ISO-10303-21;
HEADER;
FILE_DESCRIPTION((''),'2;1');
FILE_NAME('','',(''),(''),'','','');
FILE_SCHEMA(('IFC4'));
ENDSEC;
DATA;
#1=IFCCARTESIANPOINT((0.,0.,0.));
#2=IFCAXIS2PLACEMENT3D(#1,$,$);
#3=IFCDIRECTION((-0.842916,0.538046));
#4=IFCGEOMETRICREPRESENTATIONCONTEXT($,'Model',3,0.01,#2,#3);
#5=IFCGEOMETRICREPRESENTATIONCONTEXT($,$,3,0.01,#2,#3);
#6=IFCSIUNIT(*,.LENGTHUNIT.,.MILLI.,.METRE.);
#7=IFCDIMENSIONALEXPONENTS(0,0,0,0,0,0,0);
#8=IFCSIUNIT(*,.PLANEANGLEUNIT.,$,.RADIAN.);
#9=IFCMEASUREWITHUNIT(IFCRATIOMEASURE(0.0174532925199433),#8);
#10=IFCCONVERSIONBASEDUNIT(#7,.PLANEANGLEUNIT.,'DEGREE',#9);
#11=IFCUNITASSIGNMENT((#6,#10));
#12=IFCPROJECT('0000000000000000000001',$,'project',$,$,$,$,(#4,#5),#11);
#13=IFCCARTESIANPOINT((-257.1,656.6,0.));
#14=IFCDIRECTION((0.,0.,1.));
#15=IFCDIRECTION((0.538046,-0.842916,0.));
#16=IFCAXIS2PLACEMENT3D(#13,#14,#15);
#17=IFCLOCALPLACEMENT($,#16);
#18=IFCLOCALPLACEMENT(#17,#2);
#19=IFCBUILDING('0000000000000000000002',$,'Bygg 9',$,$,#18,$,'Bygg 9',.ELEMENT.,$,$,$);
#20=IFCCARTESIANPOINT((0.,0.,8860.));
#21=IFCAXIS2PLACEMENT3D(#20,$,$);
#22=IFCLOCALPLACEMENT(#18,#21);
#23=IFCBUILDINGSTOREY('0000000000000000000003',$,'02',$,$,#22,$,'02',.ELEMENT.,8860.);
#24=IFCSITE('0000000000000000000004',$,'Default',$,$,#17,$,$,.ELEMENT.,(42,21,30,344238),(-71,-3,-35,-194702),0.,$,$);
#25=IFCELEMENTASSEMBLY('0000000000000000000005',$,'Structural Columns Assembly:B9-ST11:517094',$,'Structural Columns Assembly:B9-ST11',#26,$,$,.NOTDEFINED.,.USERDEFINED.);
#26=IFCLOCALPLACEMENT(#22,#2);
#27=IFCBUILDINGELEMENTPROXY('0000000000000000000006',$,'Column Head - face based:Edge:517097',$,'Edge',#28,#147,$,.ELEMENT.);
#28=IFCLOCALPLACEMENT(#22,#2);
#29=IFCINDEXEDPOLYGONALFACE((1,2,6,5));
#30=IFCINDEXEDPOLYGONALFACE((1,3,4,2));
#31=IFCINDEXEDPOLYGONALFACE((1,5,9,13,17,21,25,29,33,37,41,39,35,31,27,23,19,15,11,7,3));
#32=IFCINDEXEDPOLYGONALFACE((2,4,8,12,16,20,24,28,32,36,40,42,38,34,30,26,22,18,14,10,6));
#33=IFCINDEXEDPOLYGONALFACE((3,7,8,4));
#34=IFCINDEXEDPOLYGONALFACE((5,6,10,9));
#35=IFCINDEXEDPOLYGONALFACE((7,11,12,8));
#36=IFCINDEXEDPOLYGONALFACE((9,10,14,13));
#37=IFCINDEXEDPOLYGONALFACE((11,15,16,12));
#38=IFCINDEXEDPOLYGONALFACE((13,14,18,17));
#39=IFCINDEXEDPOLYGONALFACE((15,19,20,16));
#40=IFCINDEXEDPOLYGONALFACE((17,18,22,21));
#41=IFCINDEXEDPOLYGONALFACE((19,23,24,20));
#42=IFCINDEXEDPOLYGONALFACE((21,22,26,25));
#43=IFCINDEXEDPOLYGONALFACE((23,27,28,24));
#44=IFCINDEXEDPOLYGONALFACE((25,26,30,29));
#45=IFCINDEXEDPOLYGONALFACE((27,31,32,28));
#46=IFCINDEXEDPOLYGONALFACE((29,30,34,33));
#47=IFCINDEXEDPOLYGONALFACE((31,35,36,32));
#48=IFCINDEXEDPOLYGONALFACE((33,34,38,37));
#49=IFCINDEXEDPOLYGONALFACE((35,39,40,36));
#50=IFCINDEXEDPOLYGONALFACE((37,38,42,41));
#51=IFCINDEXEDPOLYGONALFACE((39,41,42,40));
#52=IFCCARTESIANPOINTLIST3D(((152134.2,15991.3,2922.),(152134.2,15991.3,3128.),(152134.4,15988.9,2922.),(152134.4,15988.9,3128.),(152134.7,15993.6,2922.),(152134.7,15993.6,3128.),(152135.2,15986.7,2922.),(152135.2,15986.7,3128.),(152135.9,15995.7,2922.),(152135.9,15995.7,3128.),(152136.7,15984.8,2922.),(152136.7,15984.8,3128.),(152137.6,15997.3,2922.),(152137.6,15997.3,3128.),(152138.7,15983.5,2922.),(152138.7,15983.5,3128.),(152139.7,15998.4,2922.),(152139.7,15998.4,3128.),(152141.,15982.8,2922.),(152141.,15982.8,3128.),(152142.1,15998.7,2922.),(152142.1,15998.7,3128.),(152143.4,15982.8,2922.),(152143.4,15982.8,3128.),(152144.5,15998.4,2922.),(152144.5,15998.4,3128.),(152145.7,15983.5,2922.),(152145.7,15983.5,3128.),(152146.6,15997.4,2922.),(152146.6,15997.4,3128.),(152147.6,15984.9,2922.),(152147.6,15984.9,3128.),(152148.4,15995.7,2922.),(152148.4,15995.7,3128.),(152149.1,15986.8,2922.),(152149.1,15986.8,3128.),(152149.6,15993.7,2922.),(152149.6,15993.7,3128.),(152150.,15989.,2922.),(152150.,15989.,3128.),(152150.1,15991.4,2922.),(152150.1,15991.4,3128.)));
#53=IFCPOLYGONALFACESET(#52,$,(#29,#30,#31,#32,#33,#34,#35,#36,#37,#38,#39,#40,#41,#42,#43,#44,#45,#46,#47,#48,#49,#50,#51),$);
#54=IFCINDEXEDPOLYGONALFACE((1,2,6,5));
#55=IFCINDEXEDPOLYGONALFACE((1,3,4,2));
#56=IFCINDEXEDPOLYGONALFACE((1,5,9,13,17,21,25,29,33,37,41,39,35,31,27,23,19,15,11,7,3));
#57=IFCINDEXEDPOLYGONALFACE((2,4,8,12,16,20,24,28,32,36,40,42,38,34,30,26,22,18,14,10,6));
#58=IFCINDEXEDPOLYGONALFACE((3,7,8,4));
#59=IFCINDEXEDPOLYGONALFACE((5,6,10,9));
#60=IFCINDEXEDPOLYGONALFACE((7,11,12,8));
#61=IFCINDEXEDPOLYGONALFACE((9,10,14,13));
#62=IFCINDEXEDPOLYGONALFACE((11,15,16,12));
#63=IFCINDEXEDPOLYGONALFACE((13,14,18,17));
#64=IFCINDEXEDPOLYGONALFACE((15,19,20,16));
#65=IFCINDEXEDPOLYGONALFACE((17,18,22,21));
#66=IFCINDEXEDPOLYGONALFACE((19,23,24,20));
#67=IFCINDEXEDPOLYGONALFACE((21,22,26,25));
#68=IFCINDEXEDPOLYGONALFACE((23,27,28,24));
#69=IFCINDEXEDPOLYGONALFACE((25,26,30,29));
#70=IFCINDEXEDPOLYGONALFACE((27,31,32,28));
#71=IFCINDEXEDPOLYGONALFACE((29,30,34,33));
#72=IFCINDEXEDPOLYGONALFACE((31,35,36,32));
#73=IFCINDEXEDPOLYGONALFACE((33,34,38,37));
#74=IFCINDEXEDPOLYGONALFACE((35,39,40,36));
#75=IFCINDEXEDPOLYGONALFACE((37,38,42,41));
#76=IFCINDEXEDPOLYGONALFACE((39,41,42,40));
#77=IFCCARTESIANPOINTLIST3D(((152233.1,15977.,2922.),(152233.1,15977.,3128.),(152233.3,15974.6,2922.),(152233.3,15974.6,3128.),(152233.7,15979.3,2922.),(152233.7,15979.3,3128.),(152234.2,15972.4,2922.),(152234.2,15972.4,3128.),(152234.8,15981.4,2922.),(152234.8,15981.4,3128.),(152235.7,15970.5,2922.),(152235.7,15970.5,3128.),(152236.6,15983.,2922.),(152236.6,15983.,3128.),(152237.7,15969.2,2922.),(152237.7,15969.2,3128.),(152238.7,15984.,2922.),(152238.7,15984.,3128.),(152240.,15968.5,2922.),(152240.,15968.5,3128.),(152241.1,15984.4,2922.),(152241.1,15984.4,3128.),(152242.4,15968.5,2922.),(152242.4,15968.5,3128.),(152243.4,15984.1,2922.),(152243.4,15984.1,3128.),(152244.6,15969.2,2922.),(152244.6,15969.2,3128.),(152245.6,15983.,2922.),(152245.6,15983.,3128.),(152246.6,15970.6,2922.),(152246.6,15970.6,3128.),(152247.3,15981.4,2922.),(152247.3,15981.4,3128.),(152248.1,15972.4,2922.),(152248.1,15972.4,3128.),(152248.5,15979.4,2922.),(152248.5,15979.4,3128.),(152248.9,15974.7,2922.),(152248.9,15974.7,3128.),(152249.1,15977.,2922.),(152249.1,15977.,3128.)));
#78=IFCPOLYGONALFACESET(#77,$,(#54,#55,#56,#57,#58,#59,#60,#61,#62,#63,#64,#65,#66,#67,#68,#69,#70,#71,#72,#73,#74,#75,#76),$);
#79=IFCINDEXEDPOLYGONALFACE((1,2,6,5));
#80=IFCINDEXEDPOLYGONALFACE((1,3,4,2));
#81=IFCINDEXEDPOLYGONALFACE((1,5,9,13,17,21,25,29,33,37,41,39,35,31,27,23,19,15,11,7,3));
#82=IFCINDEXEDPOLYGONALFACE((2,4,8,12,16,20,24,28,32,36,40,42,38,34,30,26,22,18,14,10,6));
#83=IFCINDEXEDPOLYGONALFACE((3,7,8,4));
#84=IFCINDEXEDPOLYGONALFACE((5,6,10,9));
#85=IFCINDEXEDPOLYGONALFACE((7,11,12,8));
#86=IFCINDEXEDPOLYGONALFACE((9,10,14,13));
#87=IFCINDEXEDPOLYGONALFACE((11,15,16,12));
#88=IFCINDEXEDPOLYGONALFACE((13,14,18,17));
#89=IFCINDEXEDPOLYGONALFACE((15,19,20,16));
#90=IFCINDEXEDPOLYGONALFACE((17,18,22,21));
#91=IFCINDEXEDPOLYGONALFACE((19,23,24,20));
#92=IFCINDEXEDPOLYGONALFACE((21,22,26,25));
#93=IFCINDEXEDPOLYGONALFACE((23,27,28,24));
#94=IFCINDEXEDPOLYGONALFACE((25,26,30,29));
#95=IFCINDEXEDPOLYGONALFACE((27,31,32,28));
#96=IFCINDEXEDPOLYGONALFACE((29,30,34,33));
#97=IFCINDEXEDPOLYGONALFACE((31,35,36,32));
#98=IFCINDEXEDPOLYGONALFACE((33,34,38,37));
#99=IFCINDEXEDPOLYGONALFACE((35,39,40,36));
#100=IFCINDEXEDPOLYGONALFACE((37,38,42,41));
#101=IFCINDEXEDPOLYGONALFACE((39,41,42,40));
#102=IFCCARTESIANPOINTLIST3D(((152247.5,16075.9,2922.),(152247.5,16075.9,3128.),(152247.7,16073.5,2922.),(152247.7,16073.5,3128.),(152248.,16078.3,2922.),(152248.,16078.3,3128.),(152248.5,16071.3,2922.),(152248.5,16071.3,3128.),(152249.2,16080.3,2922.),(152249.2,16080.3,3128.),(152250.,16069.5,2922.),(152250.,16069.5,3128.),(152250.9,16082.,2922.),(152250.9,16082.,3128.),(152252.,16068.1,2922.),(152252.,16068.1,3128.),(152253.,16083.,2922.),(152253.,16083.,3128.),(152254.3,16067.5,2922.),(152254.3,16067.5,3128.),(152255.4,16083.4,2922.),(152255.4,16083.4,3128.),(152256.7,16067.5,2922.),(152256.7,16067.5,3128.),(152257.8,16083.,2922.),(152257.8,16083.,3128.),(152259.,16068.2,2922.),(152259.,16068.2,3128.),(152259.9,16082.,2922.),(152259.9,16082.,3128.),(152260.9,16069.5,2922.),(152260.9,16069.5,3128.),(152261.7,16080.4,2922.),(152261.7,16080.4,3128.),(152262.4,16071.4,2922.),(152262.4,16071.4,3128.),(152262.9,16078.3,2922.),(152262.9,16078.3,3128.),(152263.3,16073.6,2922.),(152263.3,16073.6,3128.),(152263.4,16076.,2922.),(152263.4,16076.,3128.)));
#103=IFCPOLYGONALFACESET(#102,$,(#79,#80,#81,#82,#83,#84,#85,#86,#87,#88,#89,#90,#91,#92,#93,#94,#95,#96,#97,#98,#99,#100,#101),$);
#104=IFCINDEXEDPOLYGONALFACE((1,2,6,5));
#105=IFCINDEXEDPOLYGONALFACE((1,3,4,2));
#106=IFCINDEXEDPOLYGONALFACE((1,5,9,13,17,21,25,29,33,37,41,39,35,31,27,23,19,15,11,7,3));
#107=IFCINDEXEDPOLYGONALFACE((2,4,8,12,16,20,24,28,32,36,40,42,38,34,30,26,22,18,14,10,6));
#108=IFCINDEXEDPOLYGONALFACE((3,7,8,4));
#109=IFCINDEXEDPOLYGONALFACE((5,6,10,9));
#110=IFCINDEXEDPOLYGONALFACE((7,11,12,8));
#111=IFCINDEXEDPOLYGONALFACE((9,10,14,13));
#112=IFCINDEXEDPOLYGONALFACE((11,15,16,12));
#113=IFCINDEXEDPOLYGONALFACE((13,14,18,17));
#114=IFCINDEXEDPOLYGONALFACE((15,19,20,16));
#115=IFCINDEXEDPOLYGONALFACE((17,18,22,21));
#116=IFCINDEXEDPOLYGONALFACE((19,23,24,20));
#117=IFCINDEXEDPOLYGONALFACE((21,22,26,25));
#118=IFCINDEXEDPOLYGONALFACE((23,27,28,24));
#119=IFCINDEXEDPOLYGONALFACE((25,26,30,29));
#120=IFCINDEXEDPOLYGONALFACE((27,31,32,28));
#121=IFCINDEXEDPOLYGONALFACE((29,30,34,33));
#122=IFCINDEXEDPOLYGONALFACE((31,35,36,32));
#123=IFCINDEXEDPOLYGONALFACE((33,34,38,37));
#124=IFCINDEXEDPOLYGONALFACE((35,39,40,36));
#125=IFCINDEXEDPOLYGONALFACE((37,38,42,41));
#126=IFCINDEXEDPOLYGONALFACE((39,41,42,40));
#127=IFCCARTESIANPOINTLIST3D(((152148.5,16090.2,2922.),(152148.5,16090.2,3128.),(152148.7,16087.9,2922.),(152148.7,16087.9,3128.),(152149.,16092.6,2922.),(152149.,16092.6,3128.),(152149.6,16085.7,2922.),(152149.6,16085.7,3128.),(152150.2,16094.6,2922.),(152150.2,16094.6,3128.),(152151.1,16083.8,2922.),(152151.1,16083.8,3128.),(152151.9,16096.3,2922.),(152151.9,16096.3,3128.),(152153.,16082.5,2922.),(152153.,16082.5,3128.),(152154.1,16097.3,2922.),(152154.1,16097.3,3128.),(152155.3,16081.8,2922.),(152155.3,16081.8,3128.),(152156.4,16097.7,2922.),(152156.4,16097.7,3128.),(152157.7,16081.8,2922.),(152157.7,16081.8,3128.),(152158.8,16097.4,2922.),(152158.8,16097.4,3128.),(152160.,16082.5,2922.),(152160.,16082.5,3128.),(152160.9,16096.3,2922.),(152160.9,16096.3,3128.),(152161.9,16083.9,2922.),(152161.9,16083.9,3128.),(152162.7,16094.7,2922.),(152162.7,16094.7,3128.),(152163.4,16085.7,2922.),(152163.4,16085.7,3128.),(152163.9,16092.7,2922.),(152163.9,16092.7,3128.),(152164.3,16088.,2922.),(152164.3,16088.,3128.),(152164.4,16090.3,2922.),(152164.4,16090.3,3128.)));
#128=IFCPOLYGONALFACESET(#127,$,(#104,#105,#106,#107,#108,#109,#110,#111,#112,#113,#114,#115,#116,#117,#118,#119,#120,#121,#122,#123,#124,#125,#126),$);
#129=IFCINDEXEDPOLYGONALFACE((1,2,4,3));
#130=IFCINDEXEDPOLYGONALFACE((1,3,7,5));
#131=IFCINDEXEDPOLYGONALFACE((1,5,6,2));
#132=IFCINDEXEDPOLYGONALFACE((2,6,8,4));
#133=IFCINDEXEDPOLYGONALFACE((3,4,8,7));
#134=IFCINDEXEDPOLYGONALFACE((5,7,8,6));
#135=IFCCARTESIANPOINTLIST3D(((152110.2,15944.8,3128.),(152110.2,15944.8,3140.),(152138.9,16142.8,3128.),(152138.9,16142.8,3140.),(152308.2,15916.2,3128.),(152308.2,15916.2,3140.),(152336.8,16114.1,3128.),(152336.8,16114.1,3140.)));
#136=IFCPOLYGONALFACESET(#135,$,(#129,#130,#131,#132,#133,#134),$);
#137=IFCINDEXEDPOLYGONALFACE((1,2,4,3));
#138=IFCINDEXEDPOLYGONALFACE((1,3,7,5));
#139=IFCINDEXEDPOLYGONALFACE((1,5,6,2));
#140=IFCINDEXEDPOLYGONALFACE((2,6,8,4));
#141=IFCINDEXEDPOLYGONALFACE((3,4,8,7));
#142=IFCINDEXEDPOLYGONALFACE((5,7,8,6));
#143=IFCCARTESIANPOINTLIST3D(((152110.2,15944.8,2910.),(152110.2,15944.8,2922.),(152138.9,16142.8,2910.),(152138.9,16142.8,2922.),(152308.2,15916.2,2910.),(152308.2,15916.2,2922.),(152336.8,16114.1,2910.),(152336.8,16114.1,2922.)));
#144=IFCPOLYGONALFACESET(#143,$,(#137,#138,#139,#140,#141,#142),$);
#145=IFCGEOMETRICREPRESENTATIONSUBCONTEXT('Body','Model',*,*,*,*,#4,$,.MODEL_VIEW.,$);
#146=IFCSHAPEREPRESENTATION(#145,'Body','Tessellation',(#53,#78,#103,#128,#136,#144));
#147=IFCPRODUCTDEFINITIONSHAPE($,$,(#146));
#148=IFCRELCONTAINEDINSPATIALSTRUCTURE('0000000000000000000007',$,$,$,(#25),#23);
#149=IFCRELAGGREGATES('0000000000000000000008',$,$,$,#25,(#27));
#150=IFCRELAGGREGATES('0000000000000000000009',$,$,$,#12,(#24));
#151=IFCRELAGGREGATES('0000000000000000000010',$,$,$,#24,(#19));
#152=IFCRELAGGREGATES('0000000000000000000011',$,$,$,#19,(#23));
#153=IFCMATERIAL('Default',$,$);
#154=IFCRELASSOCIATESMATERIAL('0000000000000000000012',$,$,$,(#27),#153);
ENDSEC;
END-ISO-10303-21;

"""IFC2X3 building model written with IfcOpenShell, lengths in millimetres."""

from ifc_helpers import new_model, entity, si_unit, converted_unit, direction, frame, frame_2d, origin, origin_2d_with_axis, place, context, subcontext, project, spatial, rectangle, circle, extrude, source, transform, mapped, material, element, aggregate, save


model = new_model("IFC2X3")

# Units and contexts
model_context = context("Model", 3, precision=0.01, world=origin(), true_north=direction((-0.842916, 0.538046)))
context_of_model = context(None, 3, precision=0.01, world=origin(), true_north=direction((-0.842916, 0.538046)))
body_context = subcontext(model_context, "Body", "Model", "MODEL_VIEW")
ifc_project = project(units=[si_unit("LENGTHUNIT", "METRE", prefix="MILLI"), converted_unit("PLANEANGLEUNIT", "DEGREE", entity("IfcRatioMeasure", 0.0174532925199433), si_unit("PLANEANGLEUNIT", "RADIAN"), dimensions=[0, 0, 0, 0, 0, 0, 0])], contexts=[model_context, context_of_model])

# Site, building, storey
site_placement = place(None, frame((-257.1, 656.6, 0.0), z_axis=(0.0, 0.0, 1.0), x_axis=(0.538046, -0.842916, 0.0)))
site = spatial("IfcSite", under=ifc_project, at=site_placement, Name="Default", CompositionType="ELEMENT", RefLatitude=(42, 21, 30, 344238), RefLongitude=(-71, -3, -35, -194702), RefElevation=0.0)
building_placement = place(site_placement, origin())
building = spatial("IfcBuilding", under=site, at=building_placement, Name="Bygg 9", LongName="Bygg 9", CompositionType="ELEMENT")
storey_placement = place(building_placement, frame((0.0, 0.0, 8860.0)))
storey = spatial("IfcBuildingStorey", under=building, at=storey_placement, Name="02", LongName="02", CompositionType="ELEMENT", Elevation=8860.0)

# Element assembly
assembly_1_placement = place(storey_placement, origin())
assembly_1 = element("IfcElementAssembly", 1, at=assembly_1_placement, inside=storey, Name="Structural Columns Assembly:B9-ST11:517094", ObjectType="Structural Columns Assembly:B9-ST11", AssemblyPlace="NOTDEFINED", PredefinedType="USERDEFINED")

# Building element proxy
ifc_material_1 = material(Name="Default")
shared_shape_1 = source(origin(), body_context, "Body", "SweptSolid", [
    extrude(circle(Radius=8.0, at=frame_2d((0.0, 0.0), x_axis=(1.0, 0.0))), frame((50.0, -75.0, 12.0)), (0.0, 0.0, 1.0), 206.0),
    extrude(circle(Radius=8.0, at=frame_2d((0.0, 0.0), x_axis=(1.0, 0.0))), frame((50.0, 25.0, 12.0)), (0.0, 0.0, 1.0), 206.0),
    extrude(circle(Radius=8.0, at=frame_2d((0.0, 0.0), x_axis=(1.0, 0.0))), frame((-50.0, 25.0, 12.0)), (0.0, 0.0, 1.0), 206.0),
    extrude(circle(Radius=8.0, at=frame_2d((0.0, 0.0), x_axis=(1.0, 0.0))), frame((-50.0, -75.0, 12.0)), (0.0, 0.0, 1.0), 206.0),
    extrude(rectangle(XDim=200.0, YDim=200.0, at=origin_2d_with_axis()), frame((0.0, 0.0, 218.0), z_axis=(0.0, 0.0, 1.0), x_axis=(-1.0, 0.0, 0.0)), (0.0, 0.0, 1.0), 12.0),
    extrude(rectangle(XDim=200.0, YDim=200.0, at=origin_2d_with_axis()), frame((0.0, 0.0, 0.0), z_axis=(0.0, 0.0, 1.0), x_axis=(0.0, 1.0, 0.0)), (0.0, 0.0, 1.0), 12.0),
])
proxy_1_placement = place(assembly_1_placement, frame((152223.5, 16029.5, 2910.0), z_axis=(0.0, 0.0, 1.0), x_axis=(-0.143216, -0.989691, 0.0)))
proxy_1 = element("IfcBuildingElementProxy", 2, at=proxy_1_placement, material=ifc_material_1, Name="Column Head - face based:Edge:517097", ObjectType="Edge", CompositionType="ELEMENT", context=body_context, shape_type="MappedRepresentation", body=[
    mapped(shared_shape_1, transform((0.0, 0.0, 0.0), scale=1.0)),
])
aggregate(assembly_1, [proxy_1])

save(model, "model.ifc")
